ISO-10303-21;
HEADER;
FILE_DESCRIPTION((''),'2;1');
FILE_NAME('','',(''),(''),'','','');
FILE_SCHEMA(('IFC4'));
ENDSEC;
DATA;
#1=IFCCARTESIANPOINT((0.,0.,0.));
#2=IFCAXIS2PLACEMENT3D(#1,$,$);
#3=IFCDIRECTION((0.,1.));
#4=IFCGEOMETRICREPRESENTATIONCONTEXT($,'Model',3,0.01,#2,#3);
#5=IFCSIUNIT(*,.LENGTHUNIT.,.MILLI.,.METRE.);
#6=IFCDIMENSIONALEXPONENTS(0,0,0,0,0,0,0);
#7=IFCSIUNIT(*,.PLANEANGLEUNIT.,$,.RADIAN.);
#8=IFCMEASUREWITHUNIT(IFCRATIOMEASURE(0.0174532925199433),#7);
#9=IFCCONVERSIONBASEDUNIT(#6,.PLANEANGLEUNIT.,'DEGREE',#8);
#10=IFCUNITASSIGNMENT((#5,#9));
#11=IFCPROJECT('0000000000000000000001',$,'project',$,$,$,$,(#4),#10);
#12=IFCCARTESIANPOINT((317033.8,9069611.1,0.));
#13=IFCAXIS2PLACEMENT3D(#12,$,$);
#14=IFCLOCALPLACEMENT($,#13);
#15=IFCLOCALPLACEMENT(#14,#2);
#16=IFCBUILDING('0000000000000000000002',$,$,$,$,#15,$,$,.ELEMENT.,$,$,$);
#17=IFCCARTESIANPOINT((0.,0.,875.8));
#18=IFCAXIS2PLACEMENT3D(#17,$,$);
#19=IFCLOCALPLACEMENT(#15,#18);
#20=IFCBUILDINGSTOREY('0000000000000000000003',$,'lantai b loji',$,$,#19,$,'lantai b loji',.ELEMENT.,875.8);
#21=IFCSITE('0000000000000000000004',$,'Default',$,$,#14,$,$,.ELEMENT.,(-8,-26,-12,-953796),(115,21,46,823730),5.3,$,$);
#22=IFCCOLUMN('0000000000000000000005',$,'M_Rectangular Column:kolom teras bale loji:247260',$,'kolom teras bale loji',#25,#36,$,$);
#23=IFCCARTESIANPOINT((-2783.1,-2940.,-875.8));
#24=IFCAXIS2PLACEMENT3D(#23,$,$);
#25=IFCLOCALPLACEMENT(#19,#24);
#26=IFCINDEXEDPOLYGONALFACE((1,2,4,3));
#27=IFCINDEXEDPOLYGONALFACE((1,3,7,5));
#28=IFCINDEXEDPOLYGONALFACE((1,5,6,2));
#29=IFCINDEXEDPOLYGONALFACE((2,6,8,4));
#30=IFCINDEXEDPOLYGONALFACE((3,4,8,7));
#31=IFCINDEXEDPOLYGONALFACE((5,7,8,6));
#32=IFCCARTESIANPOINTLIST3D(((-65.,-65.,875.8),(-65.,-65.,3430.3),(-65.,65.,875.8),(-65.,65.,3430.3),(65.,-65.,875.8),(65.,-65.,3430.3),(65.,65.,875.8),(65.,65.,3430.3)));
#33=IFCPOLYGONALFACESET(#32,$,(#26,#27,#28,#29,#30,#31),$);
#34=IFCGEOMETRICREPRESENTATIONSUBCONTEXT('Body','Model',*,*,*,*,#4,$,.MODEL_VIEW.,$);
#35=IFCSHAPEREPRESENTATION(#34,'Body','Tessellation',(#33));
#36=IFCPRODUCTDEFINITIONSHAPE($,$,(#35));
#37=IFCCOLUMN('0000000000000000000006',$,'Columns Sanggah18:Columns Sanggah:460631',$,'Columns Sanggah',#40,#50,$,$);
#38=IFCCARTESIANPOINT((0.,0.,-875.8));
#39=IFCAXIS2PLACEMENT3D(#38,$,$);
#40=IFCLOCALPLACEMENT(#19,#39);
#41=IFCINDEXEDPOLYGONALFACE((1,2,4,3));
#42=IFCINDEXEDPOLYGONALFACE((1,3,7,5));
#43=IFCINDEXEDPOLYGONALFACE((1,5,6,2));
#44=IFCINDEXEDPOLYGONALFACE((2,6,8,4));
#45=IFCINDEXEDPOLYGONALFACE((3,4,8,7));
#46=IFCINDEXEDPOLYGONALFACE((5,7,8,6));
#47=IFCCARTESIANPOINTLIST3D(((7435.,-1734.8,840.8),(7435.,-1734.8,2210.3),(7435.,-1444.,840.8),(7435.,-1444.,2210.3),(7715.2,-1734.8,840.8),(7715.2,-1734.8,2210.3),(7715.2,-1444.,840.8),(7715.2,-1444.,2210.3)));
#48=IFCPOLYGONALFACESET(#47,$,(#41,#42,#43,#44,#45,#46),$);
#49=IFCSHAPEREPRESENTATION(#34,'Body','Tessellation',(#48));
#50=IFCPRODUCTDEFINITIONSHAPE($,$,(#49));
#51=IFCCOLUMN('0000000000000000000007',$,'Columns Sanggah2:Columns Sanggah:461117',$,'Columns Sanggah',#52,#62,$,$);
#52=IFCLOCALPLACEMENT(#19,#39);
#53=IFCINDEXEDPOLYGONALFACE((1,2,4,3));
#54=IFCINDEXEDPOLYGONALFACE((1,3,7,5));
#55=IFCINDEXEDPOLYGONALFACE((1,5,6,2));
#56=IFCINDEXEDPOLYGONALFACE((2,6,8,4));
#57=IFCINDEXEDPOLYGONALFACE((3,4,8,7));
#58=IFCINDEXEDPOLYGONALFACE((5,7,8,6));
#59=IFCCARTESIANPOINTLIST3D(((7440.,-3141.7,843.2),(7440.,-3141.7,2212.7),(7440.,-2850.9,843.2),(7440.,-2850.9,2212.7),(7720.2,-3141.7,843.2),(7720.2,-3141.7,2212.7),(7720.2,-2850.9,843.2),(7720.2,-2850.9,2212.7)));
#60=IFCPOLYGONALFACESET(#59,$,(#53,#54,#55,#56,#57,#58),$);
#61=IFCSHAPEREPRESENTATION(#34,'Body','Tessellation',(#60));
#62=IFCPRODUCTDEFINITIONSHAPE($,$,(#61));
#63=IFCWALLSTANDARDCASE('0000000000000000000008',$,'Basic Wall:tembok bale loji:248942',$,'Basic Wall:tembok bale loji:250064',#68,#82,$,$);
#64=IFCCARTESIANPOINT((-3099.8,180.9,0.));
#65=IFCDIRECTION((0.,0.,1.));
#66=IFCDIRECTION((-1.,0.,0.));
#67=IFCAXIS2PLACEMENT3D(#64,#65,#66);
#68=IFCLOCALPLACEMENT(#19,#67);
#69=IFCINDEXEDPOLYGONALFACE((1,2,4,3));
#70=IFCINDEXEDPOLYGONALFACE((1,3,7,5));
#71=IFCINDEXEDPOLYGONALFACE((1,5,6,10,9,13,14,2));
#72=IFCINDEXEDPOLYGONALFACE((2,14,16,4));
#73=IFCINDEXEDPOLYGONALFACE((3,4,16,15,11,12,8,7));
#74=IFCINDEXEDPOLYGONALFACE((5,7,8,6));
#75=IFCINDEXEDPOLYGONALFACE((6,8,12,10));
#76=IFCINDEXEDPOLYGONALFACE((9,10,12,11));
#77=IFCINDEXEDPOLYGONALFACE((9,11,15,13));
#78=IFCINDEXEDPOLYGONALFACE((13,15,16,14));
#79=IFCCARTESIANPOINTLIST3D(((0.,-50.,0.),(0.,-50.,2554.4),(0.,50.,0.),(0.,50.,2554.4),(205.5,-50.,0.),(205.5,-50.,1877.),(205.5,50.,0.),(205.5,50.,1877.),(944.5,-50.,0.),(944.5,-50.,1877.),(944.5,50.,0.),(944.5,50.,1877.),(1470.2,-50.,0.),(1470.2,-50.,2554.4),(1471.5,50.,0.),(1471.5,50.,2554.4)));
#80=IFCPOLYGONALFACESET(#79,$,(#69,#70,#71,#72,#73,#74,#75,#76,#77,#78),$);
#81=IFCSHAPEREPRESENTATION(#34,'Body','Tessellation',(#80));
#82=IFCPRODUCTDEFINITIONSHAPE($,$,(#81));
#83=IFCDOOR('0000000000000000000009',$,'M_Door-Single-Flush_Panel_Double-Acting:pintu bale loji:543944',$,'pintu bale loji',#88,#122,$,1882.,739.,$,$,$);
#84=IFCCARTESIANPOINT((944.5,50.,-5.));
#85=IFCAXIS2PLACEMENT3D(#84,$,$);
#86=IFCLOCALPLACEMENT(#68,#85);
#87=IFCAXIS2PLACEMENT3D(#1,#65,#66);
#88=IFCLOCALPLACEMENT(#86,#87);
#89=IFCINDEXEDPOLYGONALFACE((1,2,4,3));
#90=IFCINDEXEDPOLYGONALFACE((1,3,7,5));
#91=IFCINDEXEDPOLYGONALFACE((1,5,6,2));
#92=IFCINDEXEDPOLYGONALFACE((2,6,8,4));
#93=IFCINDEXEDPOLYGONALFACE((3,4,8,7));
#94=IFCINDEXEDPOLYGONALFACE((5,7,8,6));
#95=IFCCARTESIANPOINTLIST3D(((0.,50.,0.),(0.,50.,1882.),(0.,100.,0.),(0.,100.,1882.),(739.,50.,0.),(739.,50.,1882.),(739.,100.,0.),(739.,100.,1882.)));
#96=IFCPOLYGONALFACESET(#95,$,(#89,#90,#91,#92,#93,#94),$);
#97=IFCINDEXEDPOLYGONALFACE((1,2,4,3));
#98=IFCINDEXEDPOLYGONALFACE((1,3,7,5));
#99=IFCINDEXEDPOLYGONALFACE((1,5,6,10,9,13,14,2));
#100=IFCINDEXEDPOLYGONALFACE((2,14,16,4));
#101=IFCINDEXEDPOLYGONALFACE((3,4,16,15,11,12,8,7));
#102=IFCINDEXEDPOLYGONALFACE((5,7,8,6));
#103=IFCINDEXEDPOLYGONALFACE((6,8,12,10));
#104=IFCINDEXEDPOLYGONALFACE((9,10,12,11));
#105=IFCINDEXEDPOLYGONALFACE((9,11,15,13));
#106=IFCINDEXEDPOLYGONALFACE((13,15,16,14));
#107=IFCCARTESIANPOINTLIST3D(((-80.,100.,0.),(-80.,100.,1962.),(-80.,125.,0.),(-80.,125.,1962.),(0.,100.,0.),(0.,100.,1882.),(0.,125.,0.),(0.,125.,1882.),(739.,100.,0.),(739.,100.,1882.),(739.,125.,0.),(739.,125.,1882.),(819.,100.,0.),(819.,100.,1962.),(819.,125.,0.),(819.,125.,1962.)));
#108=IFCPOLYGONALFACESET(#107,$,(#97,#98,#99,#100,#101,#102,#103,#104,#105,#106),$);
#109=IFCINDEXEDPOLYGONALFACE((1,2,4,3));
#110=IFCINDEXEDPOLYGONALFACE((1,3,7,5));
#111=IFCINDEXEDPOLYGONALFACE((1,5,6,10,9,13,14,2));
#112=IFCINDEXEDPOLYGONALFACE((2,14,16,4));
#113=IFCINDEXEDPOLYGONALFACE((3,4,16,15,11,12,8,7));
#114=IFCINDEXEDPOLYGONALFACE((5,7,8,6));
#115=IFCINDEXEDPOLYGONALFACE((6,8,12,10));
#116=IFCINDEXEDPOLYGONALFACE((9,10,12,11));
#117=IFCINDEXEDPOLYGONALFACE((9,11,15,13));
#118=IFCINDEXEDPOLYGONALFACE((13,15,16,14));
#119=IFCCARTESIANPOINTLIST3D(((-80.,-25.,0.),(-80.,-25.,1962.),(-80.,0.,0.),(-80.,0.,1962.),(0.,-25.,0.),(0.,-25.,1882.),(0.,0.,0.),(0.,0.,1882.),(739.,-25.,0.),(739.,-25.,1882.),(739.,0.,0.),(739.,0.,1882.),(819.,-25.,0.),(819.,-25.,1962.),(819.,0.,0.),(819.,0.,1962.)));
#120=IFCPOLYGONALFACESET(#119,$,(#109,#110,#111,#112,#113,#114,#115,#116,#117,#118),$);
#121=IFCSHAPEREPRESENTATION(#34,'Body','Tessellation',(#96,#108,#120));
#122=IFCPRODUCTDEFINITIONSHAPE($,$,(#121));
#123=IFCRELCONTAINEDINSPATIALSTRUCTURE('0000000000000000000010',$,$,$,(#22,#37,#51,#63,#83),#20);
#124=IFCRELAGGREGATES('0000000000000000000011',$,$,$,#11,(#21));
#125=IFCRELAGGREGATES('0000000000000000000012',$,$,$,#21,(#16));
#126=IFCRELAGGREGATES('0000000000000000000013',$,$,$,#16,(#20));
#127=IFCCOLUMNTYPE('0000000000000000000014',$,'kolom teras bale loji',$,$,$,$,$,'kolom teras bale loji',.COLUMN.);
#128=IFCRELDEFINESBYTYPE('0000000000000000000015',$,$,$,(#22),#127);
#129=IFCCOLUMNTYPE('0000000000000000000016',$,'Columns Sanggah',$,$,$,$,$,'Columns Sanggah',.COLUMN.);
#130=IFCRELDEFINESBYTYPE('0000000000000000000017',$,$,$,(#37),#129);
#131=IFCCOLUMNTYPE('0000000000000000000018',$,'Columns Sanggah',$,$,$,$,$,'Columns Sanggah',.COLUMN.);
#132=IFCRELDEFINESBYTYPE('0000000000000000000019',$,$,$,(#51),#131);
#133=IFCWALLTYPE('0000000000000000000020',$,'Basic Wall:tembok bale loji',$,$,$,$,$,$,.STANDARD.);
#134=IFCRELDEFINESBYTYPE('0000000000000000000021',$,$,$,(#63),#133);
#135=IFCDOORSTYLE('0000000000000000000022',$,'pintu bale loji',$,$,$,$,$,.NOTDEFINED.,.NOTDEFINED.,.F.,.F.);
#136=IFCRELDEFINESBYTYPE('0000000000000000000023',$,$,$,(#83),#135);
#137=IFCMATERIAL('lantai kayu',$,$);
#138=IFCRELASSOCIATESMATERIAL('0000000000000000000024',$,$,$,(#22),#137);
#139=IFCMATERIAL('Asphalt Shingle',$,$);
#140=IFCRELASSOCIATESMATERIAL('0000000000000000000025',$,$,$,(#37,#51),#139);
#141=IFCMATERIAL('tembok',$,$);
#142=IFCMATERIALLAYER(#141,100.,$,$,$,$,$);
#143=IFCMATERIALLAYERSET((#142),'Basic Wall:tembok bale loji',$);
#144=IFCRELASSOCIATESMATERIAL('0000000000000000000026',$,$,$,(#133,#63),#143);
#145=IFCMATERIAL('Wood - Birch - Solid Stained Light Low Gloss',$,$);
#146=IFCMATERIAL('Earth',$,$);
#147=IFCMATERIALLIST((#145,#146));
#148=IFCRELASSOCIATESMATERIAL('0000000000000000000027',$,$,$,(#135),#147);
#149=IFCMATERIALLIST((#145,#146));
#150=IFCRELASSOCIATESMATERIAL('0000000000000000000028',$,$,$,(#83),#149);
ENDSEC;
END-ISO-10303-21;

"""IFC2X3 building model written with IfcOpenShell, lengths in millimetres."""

from ifc_helpers import new_model, entity, si_unit, converted_unit, direction, frame, frame_2d, origin, origin_2d_with_axis, place, context, subcontext, project, spatial, polyline, rectangle, outline, extrude, source, transform, mapped, material, material_list, layer, layer_set, layer_usage, type_object, type_shapes, element, fill, save


model = new_model("IFC2X3")

# Units and contexts
model_context = context("Model", 3, precision=0.01, world=origin(), true_north=direction((0.0, 1.0)))
body_context = subcontext(model_context, "Body", "Model", "MODEL_VIEW")
ifc_project = project(units=[si_unit("LENGTHUNIT", "METRE", prefix="MILLI"), converted_unit("PLANEANGLEUNIT", "DEGREE", entity("IfcRatioMeasure", 0.0174532925199433), si_unit("PLANEANGLEUNIT", "RADIAN"), dimensions=[0, 0, 0, 0, 0, 0, 0])], contexts=[model_context])

# Site, building, storey
site_placement = place(None, frame((317033.8, 9069611.1, 0.0)))
site = spatial("IfcSite", under=ifc_project, at=site_placement, Name="Default", CompositionType="ELEMENT", RefLatitude=(-8, -26, -12, -953796), RefLongitude=(115, 21, 46, 823730), RefElevation=5.3)
building_placement = place(site_placement, origin())
building = spatial("IfcBuilding", under=site, at=building_placement, CompositionType="ELEMENT")
storey_placement = place(building_placement, frame((0.0, 0.0, 875.8)))
storey = spatial("IfcBuildingStorey", under=building, at=storey_placement, Name="lantai b loji", LongName="lantai b loji", CompositionType="ELEMENT", Elevation=875.8)

# Columns
ifc_material_1 = material(Name="tembok")
ifc_material_2 = material(Name="lantai kayu")
column_type_1 = type_object("IfcColumnType", Name="kolom teras bale loji", ElementType="kolom teras bale loji", PredefinedType="COLUMN")
shared_shape_1 = source(origin(), body_context, "Body", "SweptSolid", [
    extrude(rectangle(XDim=130.0, YDim=130.0, at=origin_2d_with_axis()), frame((0.0, 0.0, 875.8), z_axis=(0.0, 0.0, 1.0), x_axis=(0.0, -1.0, 0.0)), (0.0, 0.0, 1.0), 2554.4),
])
type_shapes(column_type_1, [shared_shape_1])
column_1_placement = place(storey_placement, frame((-2783.1, -2940.0, -875.8)))
element("IfcColumn", 1, at=column_1_placement, inside=storey, type_object=column_type_1, material=ifc_material_2, Name="M_Rectangular Column:kolom teras bale loji:247260", ObjectType="kolom teras bale loji", context=body_context, shape_type="MappedRepresentation", body=[
    mapped(shared_shape_1, transform((0.0, 0.0, 0.0), scale=1.0)),
])
ifc_material_3 = material(Name="Asphalt Shingle")
column_type_2 = type_object("IfcColumnType", Name="Columns Sanggah", ElementType="Columns Sanggah", PredefinedType="COLUMN")
shared_shape_2 = source(origin(), body_context, "Body", "SweptSolid", [
    extrude(rectangle(XDim=290.8, YDim=280.2, at=origin_2d_with_axis()), frame((7575.1, -1589.4, 840.8), z_axis=(0.0, 0.0, 1.0), x_axis=(0.0, -1.0, 0.0)), (0.0, 0.0, 1.0), 1369.5),
])
type_shapes(column_type_2, [shared_shape_2])
column_2_placement = place(storey_placement, frame((0.0, 0.0, -875.8)))
element("IfcColumn", 2, at=column_2_placement, inside=storey, type_object=column_type_2, material=ifc_material_3, Name="Columns Sanggah18:Columns Sanggah:460631", ObjectType="Columns Sanggah", context=body_context, shape_type="MappedRepresentation", body=[
    mapped(shared_shape_2, transform((0.0, 0.0, 0.0), scale=1.0)),
])
column_type_3 = type_object("IfcColumnType", Name="Columns Sanggah", ElementType="Columns Sanggah", PredefinedType="COLUMN")
shared_shape_3 = source(origin(), body_context, "Body", "SweptSolid", [
    extrude(rectangle(XDim=290.8, YDim=280.2, at=frame_2d((0.0, 0.0), x_axis=(1.0, 0.0))), frame((7580.1, -2996.3, 843.2), z_axis=(0.0, 0.0, 1.0), x_axis=(0.0, -1.0, 0.0)), (0.0, 0.0, 1.0), 1369.5),
])
type_shapes(column_type_3, [shared_shape_3])
column_3_placement = place(storey_placement, frame((0.0, 0.0, -875.8)))
element("IfcColumn", 3, at=column_3_placement, inside=storey, type_object=column_type_3, material=ifc_material_3, Name="Columns Sanggah2:Columns Sanggah:461117", ObjectType="Columns Sanggah", context=body_context, shape_type="MappedRepresentation", body=[
    mapped(shared_shape_3, transform((0.0, 0.0, 0.0), scale=1.0)),
])

# Shared definitions
ifc_layer_1 = layer(ifc_material_1, 100.0)
ifc_layer_set_1 = layer_set([ifc_layer_1], Name="Basic Wall:tembok bale loji")
wall_type = type_object("IfcWallType", Name="Basic Wall:tembok bale loji", PredefinedType="STANDARD", material=ifc_layer_set_1)

# Wall, opening, door
ifc_layer_usage_1 = layer_usage(ifc_layer_set_1, "AXIS2", "NEGATIVE", 50.0)
wall_1_placement = place(storey_placement, frame((-3099.8, 180.9, 0.0), z_axis=(0.0, 0.0, 1.0), x_axis=(-1.0, 0.0, 0.0)))
wall_1 = element("IfcWallStandardCase", 4, at=wall_1_placement, inside=storey, type_object=wall_type, material=ifc_layer_usage_1, Name="Basic Wall:tembok bale loji:248942", ObjectType="Basic Wall:tembok bale loji:250064", context=body_context, shape_type="SweptSolid", body=[
    extrude(outline(polyline([(0.0, -50.0), (1470.2, -50.0), (1471.5, 50.0), (0.0, 50.0), (0.0, -50.0)])), origin(), (0.0, 0.0, 1.0), 2554.4),
])
opening_1_placement = place(wall_1_placement, frame((944.5, 50.0, -5.0)))
opening_1 = element("IfcOpeningElement", 5, at=opening_1_placement, cuts=wall_1, ObjectType="Opening", context=body_context, shape_type="SweptSolid", body=[
    extrude(rectangle(XDim=739.0, YDim=1882.0, at=frame_2d((941.0, 369.5), x_axis=(0.0, 1.0))), frame((0.0, 0.0, 0.0), z_axis=(0.0, -1.0, 0.0), x_axis=(0.0, 0.0, 1.0)), (0.0, 0.0, 1.0), 100.0),
])
ifc_material_4 = material(Name="Wood - Birch - Solid Stained Light Low Gloss")
ifc_material_5 = material(Name="Earth")
ifc_material_list_1 = material_list([ifc_material_4, ifc_material_5])
ifc_material_list_2 = material_list([ifc_material_4, ifc_material_5])
door_style = type_object("IfcDoorStyle", Name="pintu bale loji", ConstructionType="NOTDEFINED", OperationType="NOTDEFINED", ParameterTakesPrecedence=False, Sizeable=False, material=ifc_material_list_2)
shared_shape_4 = source(origin(), body_context, "Body", "SweptSolid", [
    extrude(rectangle(XDim=50.0, YDim=739.0, at=frame_2d((0.0, 0.0), x_axis=(1.0, 0.0))), frame((369.5, 75.0, 0.0), z_axis=(0.0, 0.0, 1.0), x_axis=(0.0, 1.0, 0.0)), (0.0, 0.0, 1.0), 1882.0),
    extrude(outline(polyline([(-449.5, -1001.0), (449.5, -1001.0), (449.5, 961.0), (369.5, 961.0), (369.5, -921.0), (-369.5, -921.0), (-369.5, 961.0), (-449.5, 961.0), (-449.5, -1001.0)])), frame((369.5, 100.0, 961.0), z_axis=(0.0, 1.0, 0.0), x_axis=(1.0, 0.0, 0.0)), (0.0, 0.0, 1.0), 25.0),
    extrude(outline(polyline([(-1001.0, -449.5), (961.0, -449.5), (961.0, -369.5), (-921.0, -369.5), (-921.0, 369.5), (961.0, 369.5), (961.0, 449.5), (-1001.0, 449.5), (-1001.0, -449.5)])), frame((369.5, -25.0, 961.0), z_axis=(0.0, 1.0, 0.0), x_axis=(0.0, 0.0, -1.0)), (0.0, 0.0, 1.0), 25.0),
])
type_shapes(door_style, [shared_shape_4])
door_1_placement = place(opening_1_placement, frame((0.0, 0.0, 0.0), z_axis=(0.0, 0.0, 1.0), x_axis=(-1.0, 0.0, 0.0)))
door_1 = element("IfcDoor", 6, at=door_1_placement, inside=storey, type_object=door_style, material=ifc_material_list_1, Name="M_Door-Single-Flush_Panel_Double-Acting:pintu bale loji:543944", ObjectType="pintu bale loji", OverallHeight=1882.0, OverallWidth=739.0, context=body_context, shape_type="MappedRepresentation", body=[
    mapped(shared_shape_4, transform((0.0, 0.0, 0.0), scale=1.0)),
])
fill(opening_1, door_1)

save(model, "model.ifc")
